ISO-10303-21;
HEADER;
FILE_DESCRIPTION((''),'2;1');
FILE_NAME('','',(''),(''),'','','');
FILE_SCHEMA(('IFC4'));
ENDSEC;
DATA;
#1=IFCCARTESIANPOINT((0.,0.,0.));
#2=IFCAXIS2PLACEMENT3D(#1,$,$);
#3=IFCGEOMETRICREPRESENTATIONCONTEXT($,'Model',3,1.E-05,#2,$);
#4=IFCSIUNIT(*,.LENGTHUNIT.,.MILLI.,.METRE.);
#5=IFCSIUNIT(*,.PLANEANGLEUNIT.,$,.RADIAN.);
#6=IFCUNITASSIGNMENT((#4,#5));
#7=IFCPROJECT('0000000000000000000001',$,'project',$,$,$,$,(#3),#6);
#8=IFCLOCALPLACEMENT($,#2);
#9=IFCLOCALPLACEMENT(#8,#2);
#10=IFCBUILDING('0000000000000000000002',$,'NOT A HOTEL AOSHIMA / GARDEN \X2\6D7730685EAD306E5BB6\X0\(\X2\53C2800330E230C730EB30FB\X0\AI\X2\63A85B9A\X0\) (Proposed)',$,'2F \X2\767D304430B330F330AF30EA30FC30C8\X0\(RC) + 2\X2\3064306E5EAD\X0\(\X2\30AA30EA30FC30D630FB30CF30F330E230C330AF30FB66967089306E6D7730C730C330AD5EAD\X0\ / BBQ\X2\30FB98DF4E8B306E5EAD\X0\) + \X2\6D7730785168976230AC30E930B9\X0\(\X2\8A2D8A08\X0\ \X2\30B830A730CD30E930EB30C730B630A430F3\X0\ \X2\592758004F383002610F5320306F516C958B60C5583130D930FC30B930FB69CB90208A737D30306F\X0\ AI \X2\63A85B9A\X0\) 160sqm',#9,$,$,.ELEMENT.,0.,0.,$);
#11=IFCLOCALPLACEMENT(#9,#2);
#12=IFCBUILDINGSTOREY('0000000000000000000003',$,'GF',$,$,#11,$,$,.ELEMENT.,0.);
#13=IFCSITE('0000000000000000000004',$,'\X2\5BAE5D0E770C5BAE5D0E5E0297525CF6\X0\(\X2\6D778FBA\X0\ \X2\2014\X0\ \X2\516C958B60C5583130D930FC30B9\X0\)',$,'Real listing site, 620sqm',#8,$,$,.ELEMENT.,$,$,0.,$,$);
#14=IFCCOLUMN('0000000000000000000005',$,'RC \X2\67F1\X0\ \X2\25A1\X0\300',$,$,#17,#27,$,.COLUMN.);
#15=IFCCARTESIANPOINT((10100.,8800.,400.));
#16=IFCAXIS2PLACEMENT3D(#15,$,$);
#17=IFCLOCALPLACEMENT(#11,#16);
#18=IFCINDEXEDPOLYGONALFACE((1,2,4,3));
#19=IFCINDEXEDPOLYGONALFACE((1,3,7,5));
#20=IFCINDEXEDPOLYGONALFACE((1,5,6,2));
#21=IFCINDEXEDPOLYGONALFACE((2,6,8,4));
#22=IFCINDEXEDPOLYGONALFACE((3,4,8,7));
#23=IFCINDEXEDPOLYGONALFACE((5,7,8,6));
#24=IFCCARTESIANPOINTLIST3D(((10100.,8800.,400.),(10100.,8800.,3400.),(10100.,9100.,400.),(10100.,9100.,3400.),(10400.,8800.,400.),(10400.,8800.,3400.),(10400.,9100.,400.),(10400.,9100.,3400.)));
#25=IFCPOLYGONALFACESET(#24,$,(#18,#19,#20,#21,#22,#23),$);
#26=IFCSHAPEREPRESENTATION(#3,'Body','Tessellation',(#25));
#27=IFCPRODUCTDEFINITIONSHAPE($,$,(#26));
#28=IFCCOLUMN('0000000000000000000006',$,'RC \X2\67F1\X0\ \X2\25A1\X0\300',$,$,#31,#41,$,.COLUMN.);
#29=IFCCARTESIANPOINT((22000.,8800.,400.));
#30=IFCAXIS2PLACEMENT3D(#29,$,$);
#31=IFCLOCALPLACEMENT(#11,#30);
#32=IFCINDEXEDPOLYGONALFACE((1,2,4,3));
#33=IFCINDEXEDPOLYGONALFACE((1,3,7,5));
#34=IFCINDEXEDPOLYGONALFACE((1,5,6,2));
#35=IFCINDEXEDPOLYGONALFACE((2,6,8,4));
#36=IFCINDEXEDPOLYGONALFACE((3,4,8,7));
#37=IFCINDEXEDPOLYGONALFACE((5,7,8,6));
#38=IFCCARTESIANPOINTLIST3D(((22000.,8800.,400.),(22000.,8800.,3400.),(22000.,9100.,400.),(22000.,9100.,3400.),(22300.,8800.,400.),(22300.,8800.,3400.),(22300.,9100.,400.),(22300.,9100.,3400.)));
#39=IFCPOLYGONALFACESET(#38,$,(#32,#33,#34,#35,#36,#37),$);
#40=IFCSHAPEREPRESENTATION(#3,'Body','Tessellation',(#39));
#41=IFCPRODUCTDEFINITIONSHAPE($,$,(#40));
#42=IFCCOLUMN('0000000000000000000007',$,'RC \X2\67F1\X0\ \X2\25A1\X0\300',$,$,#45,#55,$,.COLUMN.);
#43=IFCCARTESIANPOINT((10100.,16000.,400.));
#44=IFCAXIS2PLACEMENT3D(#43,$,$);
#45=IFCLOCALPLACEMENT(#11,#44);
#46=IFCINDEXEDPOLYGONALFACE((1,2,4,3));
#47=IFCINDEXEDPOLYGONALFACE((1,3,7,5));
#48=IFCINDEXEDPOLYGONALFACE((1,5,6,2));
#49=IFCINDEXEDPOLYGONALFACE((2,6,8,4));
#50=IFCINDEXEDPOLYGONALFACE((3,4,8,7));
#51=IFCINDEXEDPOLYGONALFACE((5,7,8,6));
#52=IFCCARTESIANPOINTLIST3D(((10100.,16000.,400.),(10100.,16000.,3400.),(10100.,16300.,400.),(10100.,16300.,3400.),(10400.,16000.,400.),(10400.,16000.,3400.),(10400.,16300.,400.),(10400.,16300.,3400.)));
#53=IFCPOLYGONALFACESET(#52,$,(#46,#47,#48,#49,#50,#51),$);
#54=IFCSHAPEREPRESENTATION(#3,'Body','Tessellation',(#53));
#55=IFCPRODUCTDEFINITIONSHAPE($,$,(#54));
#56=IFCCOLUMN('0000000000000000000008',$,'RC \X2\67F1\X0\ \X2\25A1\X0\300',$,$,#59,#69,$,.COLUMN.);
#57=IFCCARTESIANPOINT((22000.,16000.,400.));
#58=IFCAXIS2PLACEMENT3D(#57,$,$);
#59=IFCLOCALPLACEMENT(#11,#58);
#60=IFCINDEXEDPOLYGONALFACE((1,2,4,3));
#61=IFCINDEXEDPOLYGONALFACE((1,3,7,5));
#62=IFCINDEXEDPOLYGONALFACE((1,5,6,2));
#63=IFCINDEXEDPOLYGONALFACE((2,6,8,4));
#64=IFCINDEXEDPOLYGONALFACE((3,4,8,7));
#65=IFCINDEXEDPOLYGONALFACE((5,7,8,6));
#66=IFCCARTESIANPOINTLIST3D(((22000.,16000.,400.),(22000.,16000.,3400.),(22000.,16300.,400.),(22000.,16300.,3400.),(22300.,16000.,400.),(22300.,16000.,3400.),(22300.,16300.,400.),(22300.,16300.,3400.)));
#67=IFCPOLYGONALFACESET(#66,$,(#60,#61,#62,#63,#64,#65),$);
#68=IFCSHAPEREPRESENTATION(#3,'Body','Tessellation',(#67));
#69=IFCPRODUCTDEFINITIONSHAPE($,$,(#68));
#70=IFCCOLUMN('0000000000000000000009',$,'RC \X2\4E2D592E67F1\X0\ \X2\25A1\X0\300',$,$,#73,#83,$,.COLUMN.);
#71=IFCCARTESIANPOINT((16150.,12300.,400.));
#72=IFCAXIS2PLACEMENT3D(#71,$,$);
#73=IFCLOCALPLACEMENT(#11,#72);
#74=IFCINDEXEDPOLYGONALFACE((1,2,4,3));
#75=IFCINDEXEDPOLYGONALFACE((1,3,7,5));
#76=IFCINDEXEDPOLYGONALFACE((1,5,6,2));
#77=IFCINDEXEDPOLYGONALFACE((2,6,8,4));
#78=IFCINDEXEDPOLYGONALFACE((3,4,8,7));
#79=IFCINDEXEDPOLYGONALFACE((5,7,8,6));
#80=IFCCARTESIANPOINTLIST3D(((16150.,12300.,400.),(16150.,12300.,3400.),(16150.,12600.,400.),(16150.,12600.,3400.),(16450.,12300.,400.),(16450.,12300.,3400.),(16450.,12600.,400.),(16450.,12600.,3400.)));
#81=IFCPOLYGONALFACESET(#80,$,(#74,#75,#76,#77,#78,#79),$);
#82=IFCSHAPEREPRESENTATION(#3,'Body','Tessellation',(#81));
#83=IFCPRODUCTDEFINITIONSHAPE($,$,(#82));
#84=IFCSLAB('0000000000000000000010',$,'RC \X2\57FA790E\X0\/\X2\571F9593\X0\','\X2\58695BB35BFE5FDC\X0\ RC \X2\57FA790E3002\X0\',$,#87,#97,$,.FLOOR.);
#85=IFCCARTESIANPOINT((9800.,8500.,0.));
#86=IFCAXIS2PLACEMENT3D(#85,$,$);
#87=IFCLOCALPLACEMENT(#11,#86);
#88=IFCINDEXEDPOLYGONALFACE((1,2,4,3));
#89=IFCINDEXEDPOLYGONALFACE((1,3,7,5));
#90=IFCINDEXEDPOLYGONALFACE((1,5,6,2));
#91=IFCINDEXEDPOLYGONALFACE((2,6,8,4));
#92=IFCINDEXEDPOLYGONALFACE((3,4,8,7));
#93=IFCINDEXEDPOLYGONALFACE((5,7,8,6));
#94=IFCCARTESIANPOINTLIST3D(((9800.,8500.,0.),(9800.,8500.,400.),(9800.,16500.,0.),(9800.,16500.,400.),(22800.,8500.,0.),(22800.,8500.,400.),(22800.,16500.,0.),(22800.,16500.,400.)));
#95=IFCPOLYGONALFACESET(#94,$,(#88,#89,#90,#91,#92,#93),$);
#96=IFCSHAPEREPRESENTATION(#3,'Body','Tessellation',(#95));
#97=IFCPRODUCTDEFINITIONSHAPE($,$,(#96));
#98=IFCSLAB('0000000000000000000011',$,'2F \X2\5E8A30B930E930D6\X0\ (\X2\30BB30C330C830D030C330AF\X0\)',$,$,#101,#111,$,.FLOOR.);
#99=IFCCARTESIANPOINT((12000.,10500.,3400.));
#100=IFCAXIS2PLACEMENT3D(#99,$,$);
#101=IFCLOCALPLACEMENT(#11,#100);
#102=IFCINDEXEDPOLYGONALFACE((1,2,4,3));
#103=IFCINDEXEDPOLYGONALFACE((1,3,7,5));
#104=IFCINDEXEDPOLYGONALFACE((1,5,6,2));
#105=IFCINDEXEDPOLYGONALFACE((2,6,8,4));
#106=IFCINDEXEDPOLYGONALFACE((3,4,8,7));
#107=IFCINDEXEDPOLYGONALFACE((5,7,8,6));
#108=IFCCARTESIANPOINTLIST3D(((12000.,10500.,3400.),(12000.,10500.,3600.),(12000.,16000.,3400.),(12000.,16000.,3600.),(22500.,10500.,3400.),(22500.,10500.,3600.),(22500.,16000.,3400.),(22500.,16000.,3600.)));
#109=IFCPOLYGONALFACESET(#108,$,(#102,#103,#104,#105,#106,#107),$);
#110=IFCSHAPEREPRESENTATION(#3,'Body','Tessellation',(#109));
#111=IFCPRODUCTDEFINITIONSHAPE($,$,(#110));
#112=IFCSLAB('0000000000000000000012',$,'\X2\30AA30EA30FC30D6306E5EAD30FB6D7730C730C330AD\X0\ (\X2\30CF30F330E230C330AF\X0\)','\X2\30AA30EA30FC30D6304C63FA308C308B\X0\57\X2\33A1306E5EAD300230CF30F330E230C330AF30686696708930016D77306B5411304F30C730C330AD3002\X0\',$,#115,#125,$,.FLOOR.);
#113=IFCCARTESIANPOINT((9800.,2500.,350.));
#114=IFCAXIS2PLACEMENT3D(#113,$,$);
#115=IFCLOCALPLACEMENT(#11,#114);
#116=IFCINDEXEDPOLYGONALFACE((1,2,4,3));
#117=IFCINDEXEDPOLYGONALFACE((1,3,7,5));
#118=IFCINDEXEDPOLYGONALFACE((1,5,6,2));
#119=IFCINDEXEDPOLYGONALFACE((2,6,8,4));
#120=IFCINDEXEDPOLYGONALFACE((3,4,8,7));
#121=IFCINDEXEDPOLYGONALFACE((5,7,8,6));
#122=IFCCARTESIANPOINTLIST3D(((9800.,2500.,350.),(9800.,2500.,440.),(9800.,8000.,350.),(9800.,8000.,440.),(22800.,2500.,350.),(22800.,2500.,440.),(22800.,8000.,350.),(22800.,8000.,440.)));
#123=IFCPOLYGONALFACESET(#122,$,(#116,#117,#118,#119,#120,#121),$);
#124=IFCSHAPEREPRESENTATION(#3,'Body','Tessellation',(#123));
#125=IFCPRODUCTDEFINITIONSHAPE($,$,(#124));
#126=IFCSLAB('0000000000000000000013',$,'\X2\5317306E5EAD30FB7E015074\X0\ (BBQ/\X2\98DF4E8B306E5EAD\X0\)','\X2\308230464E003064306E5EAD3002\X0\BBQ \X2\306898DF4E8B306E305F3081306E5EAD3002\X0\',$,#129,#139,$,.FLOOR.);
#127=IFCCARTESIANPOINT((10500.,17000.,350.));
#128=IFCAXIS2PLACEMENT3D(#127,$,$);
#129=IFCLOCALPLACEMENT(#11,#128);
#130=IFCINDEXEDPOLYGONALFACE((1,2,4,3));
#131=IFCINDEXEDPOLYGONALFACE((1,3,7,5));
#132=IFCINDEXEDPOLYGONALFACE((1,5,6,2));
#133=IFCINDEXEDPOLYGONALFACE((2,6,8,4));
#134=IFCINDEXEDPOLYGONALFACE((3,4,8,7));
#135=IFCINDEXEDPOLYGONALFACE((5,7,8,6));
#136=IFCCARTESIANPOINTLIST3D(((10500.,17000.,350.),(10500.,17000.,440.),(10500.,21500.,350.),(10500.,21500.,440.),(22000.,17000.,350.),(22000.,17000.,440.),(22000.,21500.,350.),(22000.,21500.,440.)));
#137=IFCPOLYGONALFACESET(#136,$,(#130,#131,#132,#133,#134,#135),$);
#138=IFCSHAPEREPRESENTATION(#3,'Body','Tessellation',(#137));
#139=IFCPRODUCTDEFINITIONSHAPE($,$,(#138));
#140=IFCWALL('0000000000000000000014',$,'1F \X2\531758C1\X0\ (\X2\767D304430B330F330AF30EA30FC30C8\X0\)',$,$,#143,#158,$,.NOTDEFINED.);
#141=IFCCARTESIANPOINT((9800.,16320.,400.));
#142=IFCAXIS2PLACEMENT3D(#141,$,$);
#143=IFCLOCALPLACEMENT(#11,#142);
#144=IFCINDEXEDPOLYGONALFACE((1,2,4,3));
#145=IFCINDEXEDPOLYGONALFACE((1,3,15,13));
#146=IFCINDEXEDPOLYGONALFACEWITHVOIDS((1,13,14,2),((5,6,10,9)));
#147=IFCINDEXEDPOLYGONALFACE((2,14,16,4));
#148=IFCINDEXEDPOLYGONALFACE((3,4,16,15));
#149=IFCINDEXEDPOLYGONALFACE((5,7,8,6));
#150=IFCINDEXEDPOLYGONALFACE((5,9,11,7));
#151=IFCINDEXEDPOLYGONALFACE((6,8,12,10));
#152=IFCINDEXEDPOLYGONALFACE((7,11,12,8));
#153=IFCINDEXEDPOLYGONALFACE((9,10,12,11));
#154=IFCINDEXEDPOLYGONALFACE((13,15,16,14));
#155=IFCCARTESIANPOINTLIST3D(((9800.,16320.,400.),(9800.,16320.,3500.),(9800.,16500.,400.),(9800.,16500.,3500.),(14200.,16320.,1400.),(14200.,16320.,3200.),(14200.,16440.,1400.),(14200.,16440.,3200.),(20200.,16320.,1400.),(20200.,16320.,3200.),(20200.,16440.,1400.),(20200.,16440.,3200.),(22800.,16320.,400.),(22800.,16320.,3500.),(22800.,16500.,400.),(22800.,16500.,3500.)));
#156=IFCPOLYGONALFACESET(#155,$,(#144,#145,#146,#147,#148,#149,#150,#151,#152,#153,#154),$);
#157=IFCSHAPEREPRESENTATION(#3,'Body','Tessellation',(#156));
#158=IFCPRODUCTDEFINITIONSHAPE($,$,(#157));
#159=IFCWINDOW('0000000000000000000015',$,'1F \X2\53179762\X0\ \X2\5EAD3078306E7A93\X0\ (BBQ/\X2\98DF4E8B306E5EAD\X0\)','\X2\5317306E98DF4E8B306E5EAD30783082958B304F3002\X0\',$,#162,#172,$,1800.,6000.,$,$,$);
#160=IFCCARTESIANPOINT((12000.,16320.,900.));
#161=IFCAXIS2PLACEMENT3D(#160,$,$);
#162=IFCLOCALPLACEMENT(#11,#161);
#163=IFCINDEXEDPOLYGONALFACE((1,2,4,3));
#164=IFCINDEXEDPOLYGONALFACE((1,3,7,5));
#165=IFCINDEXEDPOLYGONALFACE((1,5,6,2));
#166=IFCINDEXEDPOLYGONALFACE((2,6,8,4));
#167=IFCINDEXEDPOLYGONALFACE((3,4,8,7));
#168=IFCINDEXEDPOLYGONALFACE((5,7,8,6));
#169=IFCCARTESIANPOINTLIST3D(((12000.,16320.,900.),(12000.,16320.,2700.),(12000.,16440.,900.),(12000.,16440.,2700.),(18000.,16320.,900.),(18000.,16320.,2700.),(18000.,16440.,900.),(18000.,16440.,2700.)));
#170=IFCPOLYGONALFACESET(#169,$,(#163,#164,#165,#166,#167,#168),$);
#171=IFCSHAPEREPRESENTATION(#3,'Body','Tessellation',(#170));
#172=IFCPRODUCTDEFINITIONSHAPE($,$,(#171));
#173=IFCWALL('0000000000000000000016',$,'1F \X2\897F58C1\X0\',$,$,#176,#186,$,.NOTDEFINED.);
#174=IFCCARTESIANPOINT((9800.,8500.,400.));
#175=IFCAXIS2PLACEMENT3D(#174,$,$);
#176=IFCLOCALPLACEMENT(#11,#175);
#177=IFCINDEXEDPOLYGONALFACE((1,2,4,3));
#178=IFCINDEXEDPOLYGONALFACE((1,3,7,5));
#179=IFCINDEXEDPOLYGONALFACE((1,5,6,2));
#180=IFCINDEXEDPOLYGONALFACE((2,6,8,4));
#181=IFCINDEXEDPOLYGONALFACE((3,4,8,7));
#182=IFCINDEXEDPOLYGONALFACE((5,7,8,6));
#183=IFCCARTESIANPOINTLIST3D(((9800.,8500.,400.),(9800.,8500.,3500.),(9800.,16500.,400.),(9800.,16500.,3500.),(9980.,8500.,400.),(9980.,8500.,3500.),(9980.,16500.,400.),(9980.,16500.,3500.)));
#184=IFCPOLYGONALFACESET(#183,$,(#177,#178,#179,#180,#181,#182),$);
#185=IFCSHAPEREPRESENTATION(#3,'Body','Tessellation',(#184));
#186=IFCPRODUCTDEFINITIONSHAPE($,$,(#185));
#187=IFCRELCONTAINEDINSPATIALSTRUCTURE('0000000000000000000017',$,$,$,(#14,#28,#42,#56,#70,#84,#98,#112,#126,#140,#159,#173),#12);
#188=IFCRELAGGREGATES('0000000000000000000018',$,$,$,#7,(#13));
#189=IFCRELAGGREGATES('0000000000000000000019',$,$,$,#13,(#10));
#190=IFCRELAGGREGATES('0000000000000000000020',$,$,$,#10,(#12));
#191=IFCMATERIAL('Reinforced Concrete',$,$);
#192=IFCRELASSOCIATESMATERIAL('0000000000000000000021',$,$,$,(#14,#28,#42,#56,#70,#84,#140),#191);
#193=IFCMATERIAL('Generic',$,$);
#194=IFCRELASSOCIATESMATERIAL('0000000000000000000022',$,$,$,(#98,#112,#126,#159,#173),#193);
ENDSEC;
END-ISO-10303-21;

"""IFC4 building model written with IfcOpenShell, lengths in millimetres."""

from ifc_helpers import new_model, si_unit, frame, frame_2d, origin, place, context, project, spatial, rectangle, extrude, material, element, fill, save


model = new_model("IFC4")

# Units and contexts
model_context = context("Model", 3, precision=1e-05, world=origin())
ifc_project = project(units=[si_unit("LENGTHUNIT", "METRE", prefix="MILLI"), si_unit("PLANEANGLEUNIT", "RADIAN")], contexts=[model_context])

# Site, building, storey
site_placement = place(None, origin())
site = spatial("IfcSite", under=ifc_project, at=site_placement, Name="宮崎県宮崎市青島(海辺 — 公開情報ベース)", ObjectType="Real listing site, 620sqm", CompositionType="ELEMENT", RefElevation=0.0)
building_placement = place(site_placement, origin())
building = spatial("IfcBuilding", under=site, at=building_placement, Name="NOT A HOTEL AOSHIMA / GARDEN 海と庭の家(参考モデル・AI推定) (Proposed)", ObjectType="2F 白いコンクリート(RC) + 2つの庭(オリーブ・ハンモック・暖炉の海デッキ庭 / BBQ・食事の庭) + 海へ全面ガラス(設計 ジェネラルデザイン 大堀伸。意匠は公開情報ベース・構造詳細は AI 推定) 160sqm", CompositionType="ELEMENT", ElevationOfRefHeight=0.0, ElevationOfTerrain=0.0)
storey_placement = place(building_placement, origin())
storey = spatial("IfcBuildingStorey", under=building, at=storey_placement, Name="GF", CompositionType="ELEMENT", Elevation=0.0)

# Columns
ifc_material_1 = material(Name="Reinforced Concrete")
column_1_placement = place(storey_placement, frame((10100.0, 8800.0, 400.0)))
element("IfcColumn", 1, at=column_1_placement, inside=storey, material=ifc_material_1, Name="RC 柱 □300", PredefinedType="COLUMN", context=model_context, shape_type="SweptSolid", body=[
    extrude(rectangle(XDim=300.0, YDim=300.0, at=frame_2d((150.0, 150.0))), frame((10100.0, 8800.0, 400.0)), (0.0, 0.0, 1.0), 3000.0),
])
column_2_placement = place(storey_placement, frame((22000.0, 8800.0, 400.0)))
element("IfcColumn", 2, at=column_2_placement, inside=storey, material=ifc_material_1, Name="RC 柱 □300", PredefinedType="COLUMN", context=model_context, shape_type="SweptSolid", body=[
    extrude(rectangle(XDim=300.0, YDim=300.0, at=frame_2d((150.0, 150.0))), frame((22000.0, 8800.0, 400.0)), (0.0, 0.0, 1.0), 3000.0),
])
column_3_placement = place(storey_placement, frame((10100.0, 16000.0, 400.0)))
element("IfcColumn", 3, at=column_3_placement, inside=storey, material=ifc_material_1, Name="RC 柱 □300", PredefinedType="COLUMN", context=model_context, shape_type="SweptSolid", body=[
    extrude(rectangle(XDim=300.0, YDim=300.0, at=frame_2d((150.0, 150.0))), frame((10100.0, 16000.0, 400.0)), (0.0, 0.0, 1.0), 3000.0),
])
column_4_placement = place(storey_placement, frame((22000.0, 16000.0, 400.0)))
element("IfcColumn", 4, at=column_4_placement, inside=storey, material=ifc_material_1, Name="RC 柱 □300", PredefinedType="COLUMN", context=model_context, shape_type="SweptSolid", body=[
    extrude(rectangle(XDim=300.0, YDim=300.0, at=frame_2d((150.0, 150.0))), frame((22000.0, 16000.0, 400.0)), (0.0, 0.0, 1.0), 3000.0),
])
column_5_placement = place(storey_placement, frame((16150.0, 12300.0, 400.0)))
element("IfcColumn", 5, at=column_5_placement, inside=storey, material=ifc_material_1, Name="RC 中央柱 □300", PredefinedType="COLUMN", context=model_context, shape_type="SweptSolid", body=[
    extrude(rectangle(XDim=300.0, YDim=300.0, at=frame_2d((150.0, 150.0))), frame((16150.0, 12300.0, 400.0)), (0.0, 0.0, 1.0), 3000.0),
])

# Slabs
slab_1_placement = place(storey_placement, frame((9800.0, 8500.0, 0.0)))
element("IfcSlab", 6, at=slab_1_placement, inside=storey, material=ifc_material_1, Name="RC 基礎/土間", Description="塩害対応 RC 基礎。", PredefinedType="FLOOR", context=model_context, shape_type="SweptSolid", body=[
    extrude(rectangle(XDim=13000.0, YDim=8000.0, at=frame_2d((6500.0, 4000.0))), frame((9800.0, 8500.0, 0.0)), (0.0, 0.0, 1.0), 400.0),
])
ifc_material_2 = material(Name="Generic")
slab_2_placement = place(storey_placement, frame((12000.0, 10500.0, 3400.0)))
element("IfcSlab", 7, at=slab_2_placement, inside=storey, material=ifc_material_2, Name="2F 床スラブ (セットバック)", PredefinedType="FLOOR", context=model_context, shape_type="SweptSolid", body=[
    extrude(rectangle(XDim=10500.0, YDim=5500.0, at=frame_2d((5250.0, 2750.0))), frame((12000.0, 10500.0, 3400.0)), (0.0, 0.0, 1.0), 200.0),
])
slab_3_placement = place(storey_placement, frame((9800.0, 2500.0, 350.0)))
element("IfcSlab", 8, at=slab_3_placement, inside=storey, material=ifc_material_2, Name="オリーブの庭・海デッキ (ハンモック)", Description="オリーブが揺れる57㎡の庭。ハンモックと暖炉、海に向くデッキ。", PredefinedType="FLOOR", context=model_context, shape_type="SweptSolid", body=[
    extrude(rectangle(XDim=13000.0, YDim=5500.0, at=frame_2d((6500.0, 2750.0))), frame((9800.0, 2500.0, 350.0)), (0.0, 0.0, 1.0), 90.0),
])
slab_4_placement = place(storey_placement, frame((10500.0, 17000.0, 350.0)))
element("IfcSlab", 9, at=slab_4_placement, inside=storey, material=ifc_material_2, Name="北の庭・縁側 (BBQ/食事の庭)", Description="もう一つの庭。BBQ と食事のための庭。", PredefinedType="FLOOR", context=model_context, shape_type="SweptSolid", body=[
    extrude(rectangle(XDim=11500.0, YDim=4500.0, at=frame_2d((5750.0, 2250.0))), frame((10500.0, 17000.0, 350.0)), (0.0, 0.0, 1.0), 90.0),
])

# Wall, opening, window
wall_1_placement = place(storey_placement, frame((9800.0, 16320.0, 400.0)))
wall_1 = element("IfcWall", 10, at=wall_1_placement, inside=storey, material=ifc_material_1, Name="1F 北壁 (白いコンクリート)", PredefinedType="NOTDEFINED", context=model_context, shape_type="SweptSolid", body=[
    extrude(rectangle(XDim=13000.0, YDim=180.0, at=frame_2d((6500.0, 90.0))), frame((9800.0, 16320.0, 400.0)), (0.0, 0.0, 1.0), 3100.0),
])
opening_1_placement = place(storey_placement, frame((12000.0, 16320.0, 900.0)))
opening_1 = element("IfcOpeningElement", 11, at=opening_1_placement, cuts=wall_1, PredefinedType="NOTDEFINED", context=model_context, shape_type="SweptSolid", body=[
    extrude(rectangle(XDim=6000.0, YDim=120.0, at=frame_2d((3000.0, 60.0))), frame((12000.0, 16320.0, 900.0)), (0.0, 0.0, 1.0), 1800.0),
])
window_1_placement = place(storey_placement, frame((12000.0, 16320.0, 900.0)))
window_1 = element("IfcWindow", 12, at=window_1_placement, inside=storey, material=ifc_material_2, Name="1F 北面 庭への窓 (BBQ/食事の庭)", Description="北の食事の庭へも開く。", OverallHeight=1800.0, OverallWidth=6000.0, context=model_context, shape_type="SweptSolid", body=[
    extrude(rectangle(XDim=6000.0, YDim=120.0, at=frame_2d((3000.0, 60.0))), frame((12000.0, 16320.0, 900.0)), (0.0, 0.0, 1.0), 1800.0),
])
fill(opening_1, window_1)

# Wall
wall_2_placement = place(storey_placement, frame((9800.0, 8500.0, 400.0)))
element("IfcWall", 13, at=wall_2_placement, inside=storey, material=ifc_material_2, Name="1F 西壁", PredefinedType="NOTDEFINED", context=model_context, shape_type="SweptSolid", body=[
    extrude(rectangle(XDim=180.0, YDim=8000.0, at=frame_2d((90.0, 4000.0))), frame((9800.0, 8500.0, 400.0)), (0.0, 0.0, 1.0), 3100.0),
])

save(model, "model.ifc")
